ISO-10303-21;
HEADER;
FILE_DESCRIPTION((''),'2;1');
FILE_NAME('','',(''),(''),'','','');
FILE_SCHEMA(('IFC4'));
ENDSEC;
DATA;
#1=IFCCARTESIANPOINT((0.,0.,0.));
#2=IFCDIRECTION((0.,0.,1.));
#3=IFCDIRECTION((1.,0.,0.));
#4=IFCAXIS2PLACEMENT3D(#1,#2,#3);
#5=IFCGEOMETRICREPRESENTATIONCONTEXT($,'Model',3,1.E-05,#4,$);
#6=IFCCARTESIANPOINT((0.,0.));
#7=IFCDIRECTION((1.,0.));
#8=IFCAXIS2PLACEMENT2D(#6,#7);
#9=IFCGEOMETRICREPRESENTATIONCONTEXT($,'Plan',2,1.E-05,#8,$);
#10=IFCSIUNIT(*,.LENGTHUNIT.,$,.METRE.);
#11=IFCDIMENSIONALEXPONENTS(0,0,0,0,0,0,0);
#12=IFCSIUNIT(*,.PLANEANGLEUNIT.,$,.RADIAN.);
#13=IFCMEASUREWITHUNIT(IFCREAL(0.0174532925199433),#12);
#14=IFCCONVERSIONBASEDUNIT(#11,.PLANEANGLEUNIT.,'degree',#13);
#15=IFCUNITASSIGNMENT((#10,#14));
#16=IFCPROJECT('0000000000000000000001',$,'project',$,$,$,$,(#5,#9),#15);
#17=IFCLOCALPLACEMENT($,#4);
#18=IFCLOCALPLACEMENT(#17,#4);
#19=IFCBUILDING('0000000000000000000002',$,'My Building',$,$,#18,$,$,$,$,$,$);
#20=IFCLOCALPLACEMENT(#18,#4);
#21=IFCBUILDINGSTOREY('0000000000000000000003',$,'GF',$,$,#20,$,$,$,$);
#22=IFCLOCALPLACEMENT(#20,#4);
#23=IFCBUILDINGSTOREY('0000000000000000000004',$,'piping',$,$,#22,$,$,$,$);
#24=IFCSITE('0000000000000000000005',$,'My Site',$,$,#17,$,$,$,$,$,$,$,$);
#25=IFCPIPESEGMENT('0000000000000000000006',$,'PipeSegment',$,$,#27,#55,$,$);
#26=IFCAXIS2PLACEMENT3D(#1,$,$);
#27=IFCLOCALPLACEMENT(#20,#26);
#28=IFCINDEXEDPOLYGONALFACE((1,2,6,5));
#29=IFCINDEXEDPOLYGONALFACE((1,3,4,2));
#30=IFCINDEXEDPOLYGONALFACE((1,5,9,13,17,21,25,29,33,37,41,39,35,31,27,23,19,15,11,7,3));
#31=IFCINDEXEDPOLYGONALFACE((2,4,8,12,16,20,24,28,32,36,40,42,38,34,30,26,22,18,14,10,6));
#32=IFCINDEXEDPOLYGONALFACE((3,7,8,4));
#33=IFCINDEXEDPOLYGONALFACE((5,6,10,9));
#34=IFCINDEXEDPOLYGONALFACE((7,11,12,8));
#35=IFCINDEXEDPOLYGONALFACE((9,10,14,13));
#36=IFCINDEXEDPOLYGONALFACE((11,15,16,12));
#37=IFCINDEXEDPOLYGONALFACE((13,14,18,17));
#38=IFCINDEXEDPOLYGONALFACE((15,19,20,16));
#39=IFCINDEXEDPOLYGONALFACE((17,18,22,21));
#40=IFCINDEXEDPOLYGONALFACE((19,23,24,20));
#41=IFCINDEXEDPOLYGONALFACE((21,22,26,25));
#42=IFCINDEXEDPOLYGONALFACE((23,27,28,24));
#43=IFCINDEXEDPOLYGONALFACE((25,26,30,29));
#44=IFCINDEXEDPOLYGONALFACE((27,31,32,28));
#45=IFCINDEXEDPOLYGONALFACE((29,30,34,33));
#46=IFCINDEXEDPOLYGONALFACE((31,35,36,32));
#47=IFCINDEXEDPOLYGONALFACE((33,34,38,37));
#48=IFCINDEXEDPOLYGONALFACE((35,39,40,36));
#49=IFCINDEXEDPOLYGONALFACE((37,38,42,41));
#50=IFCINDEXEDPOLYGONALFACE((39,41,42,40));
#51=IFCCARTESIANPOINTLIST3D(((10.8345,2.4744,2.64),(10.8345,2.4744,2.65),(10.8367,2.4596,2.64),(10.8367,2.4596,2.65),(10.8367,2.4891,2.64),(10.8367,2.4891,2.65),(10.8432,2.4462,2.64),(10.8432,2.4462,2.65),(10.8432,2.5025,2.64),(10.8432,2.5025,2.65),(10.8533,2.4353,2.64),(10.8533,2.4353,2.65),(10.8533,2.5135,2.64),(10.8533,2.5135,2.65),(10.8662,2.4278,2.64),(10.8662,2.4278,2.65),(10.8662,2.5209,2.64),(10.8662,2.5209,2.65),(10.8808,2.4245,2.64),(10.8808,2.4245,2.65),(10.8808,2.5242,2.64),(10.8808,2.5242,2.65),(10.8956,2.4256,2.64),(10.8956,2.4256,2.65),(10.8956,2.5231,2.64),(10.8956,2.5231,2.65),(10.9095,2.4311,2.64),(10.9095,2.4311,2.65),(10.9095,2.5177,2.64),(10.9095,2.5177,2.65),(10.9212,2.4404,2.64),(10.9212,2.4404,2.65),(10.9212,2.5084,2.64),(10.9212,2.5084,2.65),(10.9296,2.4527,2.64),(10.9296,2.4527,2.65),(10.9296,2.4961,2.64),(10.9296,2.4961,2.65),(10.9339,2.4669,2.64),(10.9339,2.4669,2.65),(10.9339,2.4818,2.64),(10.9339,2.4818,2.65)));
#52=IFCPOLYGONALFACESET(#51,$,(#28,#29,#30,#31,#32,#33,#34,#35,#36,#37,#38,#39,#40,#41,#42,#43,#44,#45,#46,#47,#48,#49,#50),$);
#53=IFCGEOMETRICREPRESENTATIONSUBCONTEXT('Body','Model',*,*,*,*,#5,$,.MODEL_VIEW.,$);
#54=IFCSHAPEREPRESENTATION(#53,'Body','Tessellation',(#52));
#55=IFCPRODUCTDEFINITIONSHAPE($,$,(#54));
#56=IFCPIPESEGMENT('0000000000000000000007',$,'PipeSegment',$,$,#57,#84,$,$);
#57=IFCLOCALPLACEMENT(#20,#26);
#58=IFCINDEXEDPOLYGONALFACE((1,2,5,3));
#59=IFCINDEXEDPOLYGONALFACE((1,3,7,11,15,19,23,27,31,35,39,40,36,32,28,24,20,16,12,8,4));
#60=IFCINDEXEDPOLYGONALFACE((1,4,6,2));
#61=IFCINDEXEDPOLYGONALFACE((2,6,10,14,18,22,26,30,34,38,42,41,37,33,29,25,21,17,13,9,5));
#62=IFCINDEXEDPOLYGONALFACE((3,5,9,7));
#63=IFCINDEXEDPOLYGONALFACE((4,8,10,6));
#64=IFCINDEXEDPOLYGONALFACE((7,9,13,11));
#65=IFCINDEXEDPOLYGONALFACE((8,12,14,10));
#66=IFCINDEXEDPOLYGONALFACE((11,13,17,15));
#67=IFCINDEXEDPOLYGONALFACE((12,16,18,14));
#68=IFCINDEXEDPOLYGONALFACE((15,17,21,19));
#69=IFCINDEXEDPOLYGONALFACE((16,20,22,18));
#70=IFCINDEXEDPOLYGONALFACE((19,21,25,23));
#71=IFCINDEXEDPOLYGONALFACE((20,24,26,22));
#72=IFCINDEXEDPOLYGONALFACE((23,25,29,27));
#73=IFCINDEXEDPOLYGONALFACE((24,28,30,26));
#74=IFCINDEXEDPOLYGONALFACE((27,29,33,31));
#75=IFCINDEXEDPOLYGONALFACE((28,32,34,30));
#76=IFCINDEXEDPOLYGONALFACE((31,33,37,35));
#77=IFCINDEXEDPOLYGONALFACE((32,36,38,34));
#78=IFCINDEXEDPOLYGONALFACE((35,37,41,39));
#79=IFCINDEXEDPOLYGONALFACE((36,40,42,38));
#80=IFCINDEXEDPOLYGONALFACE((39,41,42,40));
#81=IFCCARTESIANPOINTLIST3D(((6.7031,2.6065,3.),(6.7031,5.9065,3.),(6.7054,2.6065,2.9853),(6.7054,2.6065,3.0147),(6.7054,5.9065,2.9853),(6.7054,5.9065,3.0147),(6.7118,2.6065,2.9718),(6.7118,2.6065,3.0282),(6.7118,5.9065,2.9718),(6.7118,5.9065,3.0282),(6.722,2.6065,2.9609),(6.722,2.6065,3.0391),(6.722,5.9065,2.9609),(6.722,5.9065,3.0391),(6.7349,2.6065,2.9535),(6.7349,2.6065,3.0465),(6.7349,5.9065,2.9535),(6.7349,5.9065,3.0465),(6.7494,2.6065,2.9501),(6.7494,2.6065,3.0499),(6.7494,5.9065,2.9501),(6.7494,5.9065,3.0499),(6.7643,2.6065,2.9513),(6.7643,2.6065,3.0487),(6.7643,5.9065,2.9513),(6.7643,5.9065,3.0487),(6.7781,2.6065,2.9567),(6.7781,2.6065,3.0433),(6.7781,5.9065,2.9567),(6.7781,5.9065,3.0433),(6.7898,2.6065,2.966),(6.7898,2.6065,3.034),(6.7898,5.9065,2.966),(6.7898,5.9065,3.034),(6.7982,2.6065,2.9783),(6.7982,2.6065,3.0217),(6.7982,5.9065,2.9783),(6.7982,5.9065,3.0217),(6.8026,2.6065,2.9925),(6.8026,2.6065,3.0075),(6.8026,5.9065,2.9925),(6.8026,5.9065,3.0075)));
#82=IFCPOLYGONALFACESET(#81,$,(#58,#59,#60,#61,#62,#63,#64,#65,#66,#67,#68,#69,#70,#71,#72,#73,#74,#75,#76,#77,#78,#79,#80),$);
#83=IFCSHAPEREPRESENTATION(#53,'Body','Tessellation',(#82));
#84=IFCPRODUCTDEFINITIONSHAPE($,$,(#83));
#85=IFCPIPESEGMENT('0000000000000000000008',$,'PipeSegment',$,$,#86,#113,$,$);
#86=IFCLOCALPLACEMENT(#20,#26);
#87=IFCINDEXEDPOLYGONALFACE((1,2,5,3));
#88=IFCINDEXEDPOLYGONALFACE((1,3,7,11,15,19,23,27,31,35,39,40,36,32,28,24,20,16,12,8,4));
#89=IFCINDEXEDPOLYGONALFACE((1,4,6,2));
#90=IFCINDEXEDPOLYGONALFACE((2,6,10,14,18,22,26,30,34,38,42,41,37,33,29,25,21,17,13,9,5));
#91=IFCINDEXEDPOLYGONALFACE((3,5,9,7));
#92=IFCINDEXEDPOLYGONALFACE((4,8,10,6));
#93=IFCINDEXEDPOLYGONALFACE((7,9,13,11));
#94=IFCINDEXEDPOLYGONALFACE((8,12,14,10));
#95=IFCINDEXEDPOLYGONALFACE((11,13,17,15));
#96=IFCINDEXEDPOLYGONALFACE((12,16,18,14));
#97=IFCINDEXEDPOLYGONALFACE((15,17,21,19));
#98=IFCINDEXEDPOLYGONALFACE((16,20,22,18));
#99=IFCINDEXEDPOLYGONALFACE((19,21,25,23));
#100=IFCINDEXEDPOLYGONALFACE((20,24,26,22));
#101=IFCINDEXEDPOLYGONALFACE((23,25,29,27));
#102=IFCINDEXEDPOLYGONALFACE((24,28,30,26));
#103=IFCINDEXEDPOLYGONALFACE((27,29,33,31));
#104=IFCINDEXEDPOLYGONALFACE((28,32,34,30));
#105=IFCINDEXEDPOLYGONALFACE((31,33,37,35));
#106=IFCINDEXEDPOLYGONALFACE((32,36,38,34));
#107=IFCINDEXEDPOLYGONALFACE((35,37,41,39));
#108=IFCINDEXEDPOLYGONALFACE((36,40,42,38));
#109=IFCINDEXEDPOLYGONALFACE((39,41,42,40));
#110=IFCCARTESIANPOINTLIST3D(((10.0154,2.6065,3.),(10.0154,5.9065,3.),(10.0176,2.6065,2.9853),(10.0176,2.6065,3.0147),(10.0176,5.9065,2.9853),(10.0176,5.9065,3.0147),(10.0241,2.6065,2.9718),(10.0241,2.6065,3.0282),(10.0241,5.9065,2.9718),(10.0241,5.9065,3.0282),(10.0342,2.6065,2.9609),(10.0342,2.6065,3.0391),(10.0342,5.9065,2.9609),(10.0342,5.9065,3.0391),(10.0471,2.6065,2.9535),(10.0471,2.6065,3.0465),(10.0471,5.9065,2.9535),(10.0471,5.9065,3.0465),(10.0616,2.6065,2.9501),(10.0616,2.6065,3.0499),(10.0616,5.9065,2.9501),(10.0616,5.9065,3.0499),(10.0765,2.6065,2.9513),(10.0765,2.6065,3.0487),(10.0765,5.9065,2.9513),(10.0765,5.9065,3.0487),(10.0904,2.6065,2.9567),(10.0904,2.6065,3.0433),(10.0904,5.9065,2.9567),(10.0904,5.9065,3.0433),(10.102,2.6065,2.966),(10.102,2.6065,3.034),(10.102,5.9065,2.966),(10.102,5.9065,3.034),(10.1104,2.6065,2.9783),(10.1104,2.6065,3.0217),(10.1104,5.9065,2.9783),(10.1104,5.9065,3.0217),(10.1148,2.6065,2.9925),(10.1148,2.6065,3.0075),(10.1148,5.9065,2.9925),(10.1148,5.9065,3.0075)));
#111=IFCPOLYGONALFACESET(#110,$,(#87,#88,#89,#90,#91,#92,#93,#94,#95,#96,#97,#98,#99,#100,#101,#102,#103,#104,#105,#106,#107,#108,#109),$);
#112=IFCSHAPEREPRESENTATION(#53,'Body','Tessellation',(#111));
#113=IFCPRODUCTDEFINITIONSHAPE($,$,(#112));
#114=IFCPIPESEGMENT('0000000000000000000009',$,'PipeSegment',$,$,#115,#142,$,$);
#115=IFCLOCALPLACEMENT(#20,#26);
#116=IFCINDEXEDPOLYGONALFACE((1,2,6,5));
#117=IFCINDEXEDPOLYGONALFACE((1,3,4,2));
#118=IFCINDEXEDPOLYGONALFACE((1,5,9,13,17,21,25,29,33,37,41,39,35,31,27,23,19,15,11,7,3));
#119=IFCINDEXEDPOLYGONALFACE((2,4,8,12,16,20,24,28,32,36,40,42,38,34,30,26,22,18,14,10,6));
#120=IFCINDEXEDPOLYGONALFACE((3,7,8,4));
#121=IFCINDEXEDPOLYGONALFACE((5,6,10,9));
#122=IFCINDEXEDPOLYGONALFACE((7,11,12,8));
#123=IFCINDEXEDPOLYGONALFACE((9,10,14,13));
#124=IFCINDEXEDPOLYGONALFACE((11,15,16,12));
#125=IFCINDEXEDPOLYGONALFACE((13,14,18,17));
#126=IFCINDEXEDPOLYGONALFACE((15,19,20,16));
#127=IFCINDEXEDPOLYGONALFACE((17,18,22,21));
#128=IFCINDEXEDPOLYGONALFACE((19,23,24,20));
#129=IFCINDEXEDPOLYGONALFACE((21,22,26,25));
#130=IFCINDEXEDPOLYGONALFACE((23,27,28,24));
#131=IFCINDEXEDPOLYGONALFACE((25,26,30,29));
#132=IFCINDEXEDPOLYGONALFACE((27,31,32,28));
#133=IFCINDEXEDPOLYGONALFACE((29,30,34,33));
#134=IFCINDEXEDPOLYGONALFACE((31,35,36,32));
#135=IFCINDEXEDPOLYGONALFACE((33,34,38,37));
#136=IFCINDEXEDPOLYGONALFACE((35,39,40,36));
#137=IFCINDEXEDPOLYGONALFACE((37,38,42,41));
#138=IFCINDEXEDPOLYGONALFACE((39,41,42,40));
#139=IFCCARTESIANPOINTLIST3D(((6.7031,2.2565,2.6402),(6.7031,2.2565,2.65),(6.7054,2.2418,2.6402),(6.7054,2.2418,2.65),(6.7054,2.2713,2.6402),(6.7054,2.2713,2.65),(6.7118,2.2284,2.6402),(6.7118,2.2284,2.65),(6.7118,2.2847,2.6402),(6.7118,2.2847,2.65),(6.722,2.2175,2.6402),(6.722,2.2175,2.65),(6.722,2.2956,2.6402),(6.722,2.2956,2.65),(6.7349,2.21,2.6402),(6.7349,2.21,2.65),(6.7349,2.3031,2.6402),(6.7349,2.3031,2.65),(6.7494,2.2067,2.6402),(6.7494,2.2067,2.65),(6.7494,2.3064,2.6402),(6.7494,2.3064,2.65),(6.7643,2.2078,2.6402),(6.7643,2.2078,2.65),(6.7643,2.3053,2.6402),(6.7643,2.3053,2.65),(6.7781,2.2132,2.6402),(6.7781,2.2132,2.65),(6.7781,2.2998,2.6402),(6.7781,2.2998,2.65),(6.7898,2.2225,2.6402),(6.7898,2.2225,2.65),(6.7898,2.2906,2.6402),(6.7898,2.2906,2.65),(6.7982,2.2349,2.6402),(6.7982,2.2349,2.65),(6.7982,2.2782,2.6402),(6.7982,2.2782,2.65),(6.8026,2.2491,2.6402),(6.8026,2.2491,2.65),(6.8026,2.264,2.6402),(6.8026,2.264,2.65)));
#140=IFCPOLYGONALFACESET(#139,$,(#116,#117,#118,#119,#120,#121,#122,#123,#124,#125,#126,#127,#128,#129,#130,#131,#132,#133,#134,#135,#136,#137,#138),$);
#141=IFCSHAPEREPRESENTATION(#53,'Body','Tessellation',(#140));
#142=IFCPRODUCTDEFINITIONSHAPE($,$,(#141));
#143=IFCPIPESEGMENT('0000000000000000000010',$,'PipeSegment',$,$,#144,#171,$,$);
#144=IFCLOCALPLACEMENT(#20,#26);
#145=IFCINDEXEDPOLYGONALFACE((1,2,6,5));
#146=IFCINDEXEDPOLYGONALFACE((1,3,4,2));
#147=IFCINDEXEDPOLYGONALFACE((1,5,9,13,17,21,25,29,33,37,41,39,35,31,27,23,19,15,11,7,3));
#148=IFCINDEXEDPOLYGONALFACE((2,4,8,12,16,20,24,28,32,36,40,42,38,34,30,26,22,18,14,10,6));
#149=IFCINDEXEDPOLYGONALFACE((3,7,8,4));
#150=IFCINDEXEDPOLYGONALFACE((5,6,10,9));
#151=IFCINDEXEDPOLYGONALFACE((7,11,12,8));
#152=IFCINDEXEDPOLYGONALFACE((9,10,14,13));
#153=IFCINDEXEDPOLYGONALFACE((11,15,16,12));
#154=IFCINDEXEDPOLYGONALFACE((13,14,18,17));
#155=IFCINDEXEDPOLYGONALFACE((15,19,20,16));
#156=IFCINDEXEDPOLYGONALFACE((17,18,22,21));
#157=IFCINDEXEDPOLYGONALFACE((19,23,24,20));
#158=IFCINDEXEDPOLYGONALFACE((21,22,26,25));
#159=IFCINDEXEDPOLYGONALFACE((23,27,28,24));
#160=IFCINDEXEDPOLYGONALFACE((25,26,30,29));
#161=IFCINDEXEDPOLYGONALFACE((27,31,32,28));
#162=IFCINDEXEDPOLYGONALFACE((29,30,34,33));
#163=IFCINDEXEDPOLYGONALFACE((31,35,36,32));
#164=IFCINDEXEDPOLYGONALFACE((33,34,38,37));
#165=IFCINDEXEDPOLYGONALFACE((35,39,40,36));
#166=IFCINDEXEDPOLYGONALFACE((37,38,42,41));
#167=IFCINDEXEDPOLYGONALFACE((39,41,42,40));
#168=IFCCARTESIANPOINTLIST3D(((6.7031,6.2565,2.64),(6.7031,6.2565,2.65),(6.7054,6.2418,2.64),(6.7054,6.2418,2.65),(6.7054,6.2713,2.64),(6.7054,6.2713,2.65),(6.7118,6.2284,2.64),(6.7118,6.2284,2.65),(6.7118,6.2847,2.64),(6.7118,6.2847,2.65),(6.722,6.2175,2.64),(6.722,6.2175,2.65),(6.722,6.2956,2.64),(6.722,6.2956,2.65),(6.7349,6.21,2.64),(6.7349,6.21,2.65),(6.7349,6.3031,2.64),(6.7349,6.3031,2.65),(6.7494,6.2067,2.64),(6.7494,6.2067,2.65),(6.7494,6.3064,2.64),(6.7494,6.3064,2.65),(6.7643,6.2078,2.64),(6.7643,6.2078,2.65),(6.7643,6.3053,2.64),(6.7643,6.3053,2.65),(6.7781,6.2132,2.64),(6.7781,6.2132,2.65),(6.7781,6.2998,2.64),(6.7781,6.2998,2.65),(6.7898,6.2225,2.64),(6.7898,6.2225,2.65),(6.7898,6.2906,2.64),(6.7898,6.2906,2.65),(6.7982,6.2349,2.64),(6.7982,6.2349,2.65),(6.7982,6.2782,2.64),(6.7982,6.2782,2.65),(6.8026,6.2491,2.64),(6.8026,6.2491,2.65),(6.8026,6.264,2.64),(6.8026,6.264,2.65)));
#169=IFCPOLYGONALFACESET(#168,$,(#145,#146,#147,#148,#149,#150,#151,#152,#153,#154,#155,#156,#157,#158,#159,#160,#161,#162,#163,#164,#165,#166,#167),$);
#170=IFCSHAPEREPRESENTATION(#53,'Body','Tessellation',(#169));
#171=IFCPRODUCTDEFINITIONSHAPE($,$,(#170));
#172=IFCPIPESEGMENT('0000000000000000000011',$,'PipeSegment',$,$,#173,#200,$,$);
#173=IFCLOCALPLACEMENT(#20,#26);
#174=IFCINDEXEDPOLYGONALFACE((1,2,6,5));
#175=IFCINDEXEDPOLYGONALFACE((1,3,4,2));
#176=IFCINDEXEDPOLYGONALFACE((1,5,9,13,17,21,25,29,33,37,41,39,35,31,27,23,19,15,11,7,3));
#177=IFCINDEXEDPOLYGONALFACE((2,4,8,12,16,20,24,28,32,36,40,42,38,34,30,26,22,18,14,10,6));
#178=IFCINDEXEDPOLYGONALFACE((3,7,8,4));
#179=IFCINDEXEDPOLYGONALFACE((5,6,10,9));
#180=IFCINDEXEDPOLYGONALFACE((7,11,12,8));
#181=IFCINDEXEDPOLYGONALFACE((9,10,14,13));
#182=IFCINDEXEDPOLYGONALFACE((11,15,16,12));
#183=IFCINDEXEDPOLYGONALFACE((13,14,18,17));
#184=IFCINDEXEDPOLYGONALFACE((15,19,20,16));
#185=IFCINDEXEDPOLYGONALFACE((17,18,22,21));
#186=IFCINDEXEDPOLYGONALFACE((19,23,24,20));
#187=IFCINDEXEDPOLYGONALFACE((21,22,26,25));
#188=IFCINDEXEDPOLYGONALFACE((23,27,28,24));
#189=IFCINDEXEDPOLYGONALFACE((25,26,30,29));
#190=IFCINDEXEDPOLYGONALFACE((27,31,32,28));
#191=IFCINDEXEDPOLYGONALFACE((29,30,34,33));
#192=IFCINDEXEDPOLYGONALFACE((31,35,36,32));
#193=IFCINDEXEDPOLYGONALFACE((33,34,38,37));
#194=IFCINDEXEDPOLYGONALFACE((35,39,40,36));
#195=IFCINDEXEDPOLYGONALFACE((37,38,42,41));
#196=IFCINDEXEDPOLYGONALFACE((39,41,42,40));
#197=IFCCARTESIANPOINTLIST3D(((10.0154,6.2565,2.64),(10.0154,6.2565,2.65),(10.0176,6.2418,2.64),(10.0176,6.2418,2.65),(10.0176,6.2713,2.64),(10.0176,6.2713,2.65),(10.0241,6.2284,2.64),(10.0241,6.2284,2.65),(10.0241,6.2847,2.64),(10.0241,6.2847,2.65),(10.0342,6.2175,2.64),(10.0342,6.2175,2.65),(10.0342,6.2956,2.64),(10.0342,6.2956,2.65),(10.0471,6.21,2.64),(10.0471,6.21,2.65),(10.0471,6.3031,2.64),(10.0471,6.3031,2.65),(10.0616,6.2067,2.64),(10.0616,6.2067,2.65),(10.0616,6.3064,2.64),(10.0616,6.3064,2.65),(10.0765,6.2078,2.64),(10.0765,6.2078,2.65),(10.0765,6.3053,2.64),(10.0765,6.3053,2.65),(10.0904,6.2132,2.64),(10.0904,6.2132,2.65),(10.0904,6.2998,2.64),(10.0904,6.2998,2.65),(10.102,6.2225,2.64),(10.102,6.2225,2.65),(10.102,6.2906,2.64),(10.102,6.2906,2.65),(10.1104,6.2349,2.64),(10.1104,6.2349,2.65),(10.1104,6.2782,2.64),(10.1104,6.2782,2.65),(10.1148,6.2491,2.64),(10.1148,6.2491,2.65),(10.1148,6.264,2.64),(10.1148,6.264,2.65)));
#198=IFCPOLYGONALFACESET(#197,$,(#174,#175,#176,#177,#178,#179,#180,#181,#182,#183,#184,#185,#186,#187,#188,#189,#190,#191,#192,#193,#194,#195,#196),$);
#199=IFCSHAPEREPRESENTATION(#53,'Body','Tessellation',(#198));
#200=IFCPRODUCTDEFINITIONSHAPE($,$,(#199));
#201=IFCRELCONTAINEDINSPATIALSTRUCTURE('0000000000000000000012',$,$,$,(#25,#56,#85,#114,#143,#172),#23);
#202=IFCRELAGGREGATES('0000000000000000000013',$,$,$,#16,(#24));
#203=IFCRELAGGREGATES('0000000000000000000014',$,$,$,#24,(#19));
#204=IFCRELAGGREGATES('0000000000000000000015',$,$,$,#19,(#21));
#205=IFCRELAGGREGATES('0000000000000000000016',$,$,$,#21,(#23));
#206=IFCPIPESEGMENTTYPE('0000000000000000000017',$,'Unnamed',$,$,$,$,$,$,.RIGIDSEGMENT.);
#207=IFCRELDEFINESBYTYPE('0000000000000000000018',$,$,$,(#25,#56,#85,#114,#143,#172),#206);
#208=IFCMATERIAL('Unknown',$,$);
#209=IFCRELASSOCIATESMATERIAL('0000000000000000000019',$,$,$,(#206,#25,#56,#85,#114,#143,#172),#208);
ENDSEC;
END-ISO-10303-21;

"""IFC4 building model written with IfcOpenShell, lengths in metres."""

from ifc_helpers import new_model, entity, si_unit, converted_unit, frame, origin_with_axes, origin_2d_with_axis, place, context, subcontext, project, spatial, circle, extrude, material, material_profile, profile_set, profile_usage, type_object, element, save


model = new_model("IFC4")

# Units and contexts
model_context = context("Model", 3, precision=1e-05, world=origin_with_axes())
plan_context = context("Plan", 2, precision=1e-05, world=origin_2d_with_axis())
body_context = subcontext(model_context, "Body", "Model", "MODEL_VIEW")
ifc_project = project(units=[si_unit("LENGTHUNIT", "METRE"), converted_unit("PLANEANGLEUNIT", "degree", entity("IfcReal", 0.0174532925199433), si_unit("PLANEANGLEUNIT", "RADIAN"), dimensions=[0, 0, 0, 0, 0, 0, 0])], contexts=[model_context, plan_context])

# Site, building, storeys
site_placement = place(None, origin_with_axes())
site = spatial("IfcSite", under=ifc_project, at=site_placement, Name="My Site")
building_placement = place(site_placement, origin_with_axes())
building = spatial("IfcBuilding", under=site, at=building_placement, Name="My Building")
storey_1_placement = place(building_placement, origin_with_axes())
storey_1 = spatial("IfcBuildingStorey", under=building, at=storey_1_placement, Name="GF")
storey_2_placement = place(storey_1_placement, origin_with_axes())
storey_2 = spatial("IfcBuildingStorey", under=storey_1, at=storey_2_placement, Name="piping")

# Pipe segments
ifc_material = material(Name="Unknown")
ifc_material_profile = material_profile(ifc_material, circle(Radius=0.05))
ifc_profile_set = profile_set([ifc_material_profile])
pipe_segment_type = type_object("IfcPipeSegmentType", Name="Unnamed", PredefinedType="RIGIDSEGMENT", material=ifc_profile_set)
ifc_profile_usage_1 = profile_usage(ifc_profile_set, cardinal=5)
pipe_segment_1_placement = place(storey_2_placement, frame((10.8845, 2.4744, 2.65), z_axis=(0.0, 0.0, -1.0), x_axis=(-1.0, 0.0, 0.0)))
element("IfcPipeSegment", 1, at=pipe_segment_1_placement, inside=storey_2, type_object=pipe_segment_type, material=ifc_profile_usage_1, Name="PipeSegment", context=body_context, shape_type="SweptSolid", body=[
    extrude(circle(Radius=0.05), origin_with_axes(), (0.0, 0.0, 1.0), 0.01),
])
ifc_profile_usage_2 = profile_usage(ifc_profile_set, cardinal=5)
pipe_segment_2_placement = place(storey_2_placement, frame((6.7531, 2.6065, 3.0), z_axis=(0.0, 1.0, 0.0), x_axis=(-1.0, 0.0, 0.0)))
element("IfcPipeSegment", 2, at=pipe_segment_2_placement, inside=storey_2, type_object=pipe_segment_type, material=ifc_profile_usage_2, Name="PipeSegment", context=body_context, shape_type="SweptSolid", body=[
    extrude(circle(Radius=0.05), origin_with_axes(), (0.0, 0.0, 1.0), 3.3),
])
ifc_profile_usage_3 = profile_usage(ifc_profile_set, cardinal=5)
pipe_segment_3_placement = place(storey_2_placement, frame((10.0654, 2.6065, 3.0), z_axis=(0.0, 1.0, 0.0), x_axis=(-1.0, 0.0, 0.0)))
element("IfcPipeSegment", 3, at=pipe_segment_3_placement, inside=storey_2, type_object=pipe_segment_type, material=ifc_profile_usage_3, Name="PipeSegment", context=body_context, shape_type="SweptSolid", body=[
    extrude(circle(Radius=0.05), origin_with_axes(), (0.0, 0.0, 1.0), 3.3),
])
ifc_profile_usage_4 = profile_usage(ifc_profile_set, cardinal=5)
pipe_segment_4_placement = place(storey_2_placement, frame((6.7531, 2.2565, 2.65), z_axis=(0.0, 0.0, -1.0), x_axis=(-1.0, 0.0, 0.0)))
element("IfcPipeSegment", 4, at=pipe_segment_4_placement, inside=storey_2, type_object=pipe_segment_type, material=ifc_profile_usage_4, Name="PipeSegment", context=body_context, shape_type="SweptSolid", body=[
    extrude(circle(Radius=0.05), origin_with_axes(), (0.0, 0.0, 1.0), 0.0098),
])
ifc_profile_usage_5 = profile_usage(ifc_profile_set, cardinal=5)
pipe_segment_5_placement = place(storey_2_placement, frame((6.7531, 6.2565, 2.65), z_axis=(0.0, 0.0, -1.0), x_axis=(-1.0, 0.0, 0.0)))
element("IfcPipeSegment", 5, at=pipe_segment_5_placement, inside=storey_2, type_object=pipe_segment_type, material=ifc_profile_usage_5, Name="PipeSegment", context=body_context, shape_type="SweptSolid", body=[
    extrude(circle(Radius=0.05), origin_with_axes(), (0.0, 0.0, 1.0), 0.01),
])
ifc_profile_usage_6 = profile_usage(ifc_profile_set, cardinal=5)
pipe_segment_6_placement = place(storey_2_placement, frame((10.0654, 6.2565, 2.65), z_axis=(0.0, 0.0, -1.0), x_axis=(-1.0, 0.0, 0.0)))
element("IfcPipeSegment", 6, at=pipe_segment_6_placement, inside=storey_2, type_object=pipe_segment_type, material=ifc_profile_usage_6, Name="PipeSegment", context=body_context, shape_type="SweptSolid", body=[
    extrude(circle(Radius=0.05), origin_with_axes(), (0.0, 0.0, 1.0), 0.01),
])

save(model, "model.ifc")
